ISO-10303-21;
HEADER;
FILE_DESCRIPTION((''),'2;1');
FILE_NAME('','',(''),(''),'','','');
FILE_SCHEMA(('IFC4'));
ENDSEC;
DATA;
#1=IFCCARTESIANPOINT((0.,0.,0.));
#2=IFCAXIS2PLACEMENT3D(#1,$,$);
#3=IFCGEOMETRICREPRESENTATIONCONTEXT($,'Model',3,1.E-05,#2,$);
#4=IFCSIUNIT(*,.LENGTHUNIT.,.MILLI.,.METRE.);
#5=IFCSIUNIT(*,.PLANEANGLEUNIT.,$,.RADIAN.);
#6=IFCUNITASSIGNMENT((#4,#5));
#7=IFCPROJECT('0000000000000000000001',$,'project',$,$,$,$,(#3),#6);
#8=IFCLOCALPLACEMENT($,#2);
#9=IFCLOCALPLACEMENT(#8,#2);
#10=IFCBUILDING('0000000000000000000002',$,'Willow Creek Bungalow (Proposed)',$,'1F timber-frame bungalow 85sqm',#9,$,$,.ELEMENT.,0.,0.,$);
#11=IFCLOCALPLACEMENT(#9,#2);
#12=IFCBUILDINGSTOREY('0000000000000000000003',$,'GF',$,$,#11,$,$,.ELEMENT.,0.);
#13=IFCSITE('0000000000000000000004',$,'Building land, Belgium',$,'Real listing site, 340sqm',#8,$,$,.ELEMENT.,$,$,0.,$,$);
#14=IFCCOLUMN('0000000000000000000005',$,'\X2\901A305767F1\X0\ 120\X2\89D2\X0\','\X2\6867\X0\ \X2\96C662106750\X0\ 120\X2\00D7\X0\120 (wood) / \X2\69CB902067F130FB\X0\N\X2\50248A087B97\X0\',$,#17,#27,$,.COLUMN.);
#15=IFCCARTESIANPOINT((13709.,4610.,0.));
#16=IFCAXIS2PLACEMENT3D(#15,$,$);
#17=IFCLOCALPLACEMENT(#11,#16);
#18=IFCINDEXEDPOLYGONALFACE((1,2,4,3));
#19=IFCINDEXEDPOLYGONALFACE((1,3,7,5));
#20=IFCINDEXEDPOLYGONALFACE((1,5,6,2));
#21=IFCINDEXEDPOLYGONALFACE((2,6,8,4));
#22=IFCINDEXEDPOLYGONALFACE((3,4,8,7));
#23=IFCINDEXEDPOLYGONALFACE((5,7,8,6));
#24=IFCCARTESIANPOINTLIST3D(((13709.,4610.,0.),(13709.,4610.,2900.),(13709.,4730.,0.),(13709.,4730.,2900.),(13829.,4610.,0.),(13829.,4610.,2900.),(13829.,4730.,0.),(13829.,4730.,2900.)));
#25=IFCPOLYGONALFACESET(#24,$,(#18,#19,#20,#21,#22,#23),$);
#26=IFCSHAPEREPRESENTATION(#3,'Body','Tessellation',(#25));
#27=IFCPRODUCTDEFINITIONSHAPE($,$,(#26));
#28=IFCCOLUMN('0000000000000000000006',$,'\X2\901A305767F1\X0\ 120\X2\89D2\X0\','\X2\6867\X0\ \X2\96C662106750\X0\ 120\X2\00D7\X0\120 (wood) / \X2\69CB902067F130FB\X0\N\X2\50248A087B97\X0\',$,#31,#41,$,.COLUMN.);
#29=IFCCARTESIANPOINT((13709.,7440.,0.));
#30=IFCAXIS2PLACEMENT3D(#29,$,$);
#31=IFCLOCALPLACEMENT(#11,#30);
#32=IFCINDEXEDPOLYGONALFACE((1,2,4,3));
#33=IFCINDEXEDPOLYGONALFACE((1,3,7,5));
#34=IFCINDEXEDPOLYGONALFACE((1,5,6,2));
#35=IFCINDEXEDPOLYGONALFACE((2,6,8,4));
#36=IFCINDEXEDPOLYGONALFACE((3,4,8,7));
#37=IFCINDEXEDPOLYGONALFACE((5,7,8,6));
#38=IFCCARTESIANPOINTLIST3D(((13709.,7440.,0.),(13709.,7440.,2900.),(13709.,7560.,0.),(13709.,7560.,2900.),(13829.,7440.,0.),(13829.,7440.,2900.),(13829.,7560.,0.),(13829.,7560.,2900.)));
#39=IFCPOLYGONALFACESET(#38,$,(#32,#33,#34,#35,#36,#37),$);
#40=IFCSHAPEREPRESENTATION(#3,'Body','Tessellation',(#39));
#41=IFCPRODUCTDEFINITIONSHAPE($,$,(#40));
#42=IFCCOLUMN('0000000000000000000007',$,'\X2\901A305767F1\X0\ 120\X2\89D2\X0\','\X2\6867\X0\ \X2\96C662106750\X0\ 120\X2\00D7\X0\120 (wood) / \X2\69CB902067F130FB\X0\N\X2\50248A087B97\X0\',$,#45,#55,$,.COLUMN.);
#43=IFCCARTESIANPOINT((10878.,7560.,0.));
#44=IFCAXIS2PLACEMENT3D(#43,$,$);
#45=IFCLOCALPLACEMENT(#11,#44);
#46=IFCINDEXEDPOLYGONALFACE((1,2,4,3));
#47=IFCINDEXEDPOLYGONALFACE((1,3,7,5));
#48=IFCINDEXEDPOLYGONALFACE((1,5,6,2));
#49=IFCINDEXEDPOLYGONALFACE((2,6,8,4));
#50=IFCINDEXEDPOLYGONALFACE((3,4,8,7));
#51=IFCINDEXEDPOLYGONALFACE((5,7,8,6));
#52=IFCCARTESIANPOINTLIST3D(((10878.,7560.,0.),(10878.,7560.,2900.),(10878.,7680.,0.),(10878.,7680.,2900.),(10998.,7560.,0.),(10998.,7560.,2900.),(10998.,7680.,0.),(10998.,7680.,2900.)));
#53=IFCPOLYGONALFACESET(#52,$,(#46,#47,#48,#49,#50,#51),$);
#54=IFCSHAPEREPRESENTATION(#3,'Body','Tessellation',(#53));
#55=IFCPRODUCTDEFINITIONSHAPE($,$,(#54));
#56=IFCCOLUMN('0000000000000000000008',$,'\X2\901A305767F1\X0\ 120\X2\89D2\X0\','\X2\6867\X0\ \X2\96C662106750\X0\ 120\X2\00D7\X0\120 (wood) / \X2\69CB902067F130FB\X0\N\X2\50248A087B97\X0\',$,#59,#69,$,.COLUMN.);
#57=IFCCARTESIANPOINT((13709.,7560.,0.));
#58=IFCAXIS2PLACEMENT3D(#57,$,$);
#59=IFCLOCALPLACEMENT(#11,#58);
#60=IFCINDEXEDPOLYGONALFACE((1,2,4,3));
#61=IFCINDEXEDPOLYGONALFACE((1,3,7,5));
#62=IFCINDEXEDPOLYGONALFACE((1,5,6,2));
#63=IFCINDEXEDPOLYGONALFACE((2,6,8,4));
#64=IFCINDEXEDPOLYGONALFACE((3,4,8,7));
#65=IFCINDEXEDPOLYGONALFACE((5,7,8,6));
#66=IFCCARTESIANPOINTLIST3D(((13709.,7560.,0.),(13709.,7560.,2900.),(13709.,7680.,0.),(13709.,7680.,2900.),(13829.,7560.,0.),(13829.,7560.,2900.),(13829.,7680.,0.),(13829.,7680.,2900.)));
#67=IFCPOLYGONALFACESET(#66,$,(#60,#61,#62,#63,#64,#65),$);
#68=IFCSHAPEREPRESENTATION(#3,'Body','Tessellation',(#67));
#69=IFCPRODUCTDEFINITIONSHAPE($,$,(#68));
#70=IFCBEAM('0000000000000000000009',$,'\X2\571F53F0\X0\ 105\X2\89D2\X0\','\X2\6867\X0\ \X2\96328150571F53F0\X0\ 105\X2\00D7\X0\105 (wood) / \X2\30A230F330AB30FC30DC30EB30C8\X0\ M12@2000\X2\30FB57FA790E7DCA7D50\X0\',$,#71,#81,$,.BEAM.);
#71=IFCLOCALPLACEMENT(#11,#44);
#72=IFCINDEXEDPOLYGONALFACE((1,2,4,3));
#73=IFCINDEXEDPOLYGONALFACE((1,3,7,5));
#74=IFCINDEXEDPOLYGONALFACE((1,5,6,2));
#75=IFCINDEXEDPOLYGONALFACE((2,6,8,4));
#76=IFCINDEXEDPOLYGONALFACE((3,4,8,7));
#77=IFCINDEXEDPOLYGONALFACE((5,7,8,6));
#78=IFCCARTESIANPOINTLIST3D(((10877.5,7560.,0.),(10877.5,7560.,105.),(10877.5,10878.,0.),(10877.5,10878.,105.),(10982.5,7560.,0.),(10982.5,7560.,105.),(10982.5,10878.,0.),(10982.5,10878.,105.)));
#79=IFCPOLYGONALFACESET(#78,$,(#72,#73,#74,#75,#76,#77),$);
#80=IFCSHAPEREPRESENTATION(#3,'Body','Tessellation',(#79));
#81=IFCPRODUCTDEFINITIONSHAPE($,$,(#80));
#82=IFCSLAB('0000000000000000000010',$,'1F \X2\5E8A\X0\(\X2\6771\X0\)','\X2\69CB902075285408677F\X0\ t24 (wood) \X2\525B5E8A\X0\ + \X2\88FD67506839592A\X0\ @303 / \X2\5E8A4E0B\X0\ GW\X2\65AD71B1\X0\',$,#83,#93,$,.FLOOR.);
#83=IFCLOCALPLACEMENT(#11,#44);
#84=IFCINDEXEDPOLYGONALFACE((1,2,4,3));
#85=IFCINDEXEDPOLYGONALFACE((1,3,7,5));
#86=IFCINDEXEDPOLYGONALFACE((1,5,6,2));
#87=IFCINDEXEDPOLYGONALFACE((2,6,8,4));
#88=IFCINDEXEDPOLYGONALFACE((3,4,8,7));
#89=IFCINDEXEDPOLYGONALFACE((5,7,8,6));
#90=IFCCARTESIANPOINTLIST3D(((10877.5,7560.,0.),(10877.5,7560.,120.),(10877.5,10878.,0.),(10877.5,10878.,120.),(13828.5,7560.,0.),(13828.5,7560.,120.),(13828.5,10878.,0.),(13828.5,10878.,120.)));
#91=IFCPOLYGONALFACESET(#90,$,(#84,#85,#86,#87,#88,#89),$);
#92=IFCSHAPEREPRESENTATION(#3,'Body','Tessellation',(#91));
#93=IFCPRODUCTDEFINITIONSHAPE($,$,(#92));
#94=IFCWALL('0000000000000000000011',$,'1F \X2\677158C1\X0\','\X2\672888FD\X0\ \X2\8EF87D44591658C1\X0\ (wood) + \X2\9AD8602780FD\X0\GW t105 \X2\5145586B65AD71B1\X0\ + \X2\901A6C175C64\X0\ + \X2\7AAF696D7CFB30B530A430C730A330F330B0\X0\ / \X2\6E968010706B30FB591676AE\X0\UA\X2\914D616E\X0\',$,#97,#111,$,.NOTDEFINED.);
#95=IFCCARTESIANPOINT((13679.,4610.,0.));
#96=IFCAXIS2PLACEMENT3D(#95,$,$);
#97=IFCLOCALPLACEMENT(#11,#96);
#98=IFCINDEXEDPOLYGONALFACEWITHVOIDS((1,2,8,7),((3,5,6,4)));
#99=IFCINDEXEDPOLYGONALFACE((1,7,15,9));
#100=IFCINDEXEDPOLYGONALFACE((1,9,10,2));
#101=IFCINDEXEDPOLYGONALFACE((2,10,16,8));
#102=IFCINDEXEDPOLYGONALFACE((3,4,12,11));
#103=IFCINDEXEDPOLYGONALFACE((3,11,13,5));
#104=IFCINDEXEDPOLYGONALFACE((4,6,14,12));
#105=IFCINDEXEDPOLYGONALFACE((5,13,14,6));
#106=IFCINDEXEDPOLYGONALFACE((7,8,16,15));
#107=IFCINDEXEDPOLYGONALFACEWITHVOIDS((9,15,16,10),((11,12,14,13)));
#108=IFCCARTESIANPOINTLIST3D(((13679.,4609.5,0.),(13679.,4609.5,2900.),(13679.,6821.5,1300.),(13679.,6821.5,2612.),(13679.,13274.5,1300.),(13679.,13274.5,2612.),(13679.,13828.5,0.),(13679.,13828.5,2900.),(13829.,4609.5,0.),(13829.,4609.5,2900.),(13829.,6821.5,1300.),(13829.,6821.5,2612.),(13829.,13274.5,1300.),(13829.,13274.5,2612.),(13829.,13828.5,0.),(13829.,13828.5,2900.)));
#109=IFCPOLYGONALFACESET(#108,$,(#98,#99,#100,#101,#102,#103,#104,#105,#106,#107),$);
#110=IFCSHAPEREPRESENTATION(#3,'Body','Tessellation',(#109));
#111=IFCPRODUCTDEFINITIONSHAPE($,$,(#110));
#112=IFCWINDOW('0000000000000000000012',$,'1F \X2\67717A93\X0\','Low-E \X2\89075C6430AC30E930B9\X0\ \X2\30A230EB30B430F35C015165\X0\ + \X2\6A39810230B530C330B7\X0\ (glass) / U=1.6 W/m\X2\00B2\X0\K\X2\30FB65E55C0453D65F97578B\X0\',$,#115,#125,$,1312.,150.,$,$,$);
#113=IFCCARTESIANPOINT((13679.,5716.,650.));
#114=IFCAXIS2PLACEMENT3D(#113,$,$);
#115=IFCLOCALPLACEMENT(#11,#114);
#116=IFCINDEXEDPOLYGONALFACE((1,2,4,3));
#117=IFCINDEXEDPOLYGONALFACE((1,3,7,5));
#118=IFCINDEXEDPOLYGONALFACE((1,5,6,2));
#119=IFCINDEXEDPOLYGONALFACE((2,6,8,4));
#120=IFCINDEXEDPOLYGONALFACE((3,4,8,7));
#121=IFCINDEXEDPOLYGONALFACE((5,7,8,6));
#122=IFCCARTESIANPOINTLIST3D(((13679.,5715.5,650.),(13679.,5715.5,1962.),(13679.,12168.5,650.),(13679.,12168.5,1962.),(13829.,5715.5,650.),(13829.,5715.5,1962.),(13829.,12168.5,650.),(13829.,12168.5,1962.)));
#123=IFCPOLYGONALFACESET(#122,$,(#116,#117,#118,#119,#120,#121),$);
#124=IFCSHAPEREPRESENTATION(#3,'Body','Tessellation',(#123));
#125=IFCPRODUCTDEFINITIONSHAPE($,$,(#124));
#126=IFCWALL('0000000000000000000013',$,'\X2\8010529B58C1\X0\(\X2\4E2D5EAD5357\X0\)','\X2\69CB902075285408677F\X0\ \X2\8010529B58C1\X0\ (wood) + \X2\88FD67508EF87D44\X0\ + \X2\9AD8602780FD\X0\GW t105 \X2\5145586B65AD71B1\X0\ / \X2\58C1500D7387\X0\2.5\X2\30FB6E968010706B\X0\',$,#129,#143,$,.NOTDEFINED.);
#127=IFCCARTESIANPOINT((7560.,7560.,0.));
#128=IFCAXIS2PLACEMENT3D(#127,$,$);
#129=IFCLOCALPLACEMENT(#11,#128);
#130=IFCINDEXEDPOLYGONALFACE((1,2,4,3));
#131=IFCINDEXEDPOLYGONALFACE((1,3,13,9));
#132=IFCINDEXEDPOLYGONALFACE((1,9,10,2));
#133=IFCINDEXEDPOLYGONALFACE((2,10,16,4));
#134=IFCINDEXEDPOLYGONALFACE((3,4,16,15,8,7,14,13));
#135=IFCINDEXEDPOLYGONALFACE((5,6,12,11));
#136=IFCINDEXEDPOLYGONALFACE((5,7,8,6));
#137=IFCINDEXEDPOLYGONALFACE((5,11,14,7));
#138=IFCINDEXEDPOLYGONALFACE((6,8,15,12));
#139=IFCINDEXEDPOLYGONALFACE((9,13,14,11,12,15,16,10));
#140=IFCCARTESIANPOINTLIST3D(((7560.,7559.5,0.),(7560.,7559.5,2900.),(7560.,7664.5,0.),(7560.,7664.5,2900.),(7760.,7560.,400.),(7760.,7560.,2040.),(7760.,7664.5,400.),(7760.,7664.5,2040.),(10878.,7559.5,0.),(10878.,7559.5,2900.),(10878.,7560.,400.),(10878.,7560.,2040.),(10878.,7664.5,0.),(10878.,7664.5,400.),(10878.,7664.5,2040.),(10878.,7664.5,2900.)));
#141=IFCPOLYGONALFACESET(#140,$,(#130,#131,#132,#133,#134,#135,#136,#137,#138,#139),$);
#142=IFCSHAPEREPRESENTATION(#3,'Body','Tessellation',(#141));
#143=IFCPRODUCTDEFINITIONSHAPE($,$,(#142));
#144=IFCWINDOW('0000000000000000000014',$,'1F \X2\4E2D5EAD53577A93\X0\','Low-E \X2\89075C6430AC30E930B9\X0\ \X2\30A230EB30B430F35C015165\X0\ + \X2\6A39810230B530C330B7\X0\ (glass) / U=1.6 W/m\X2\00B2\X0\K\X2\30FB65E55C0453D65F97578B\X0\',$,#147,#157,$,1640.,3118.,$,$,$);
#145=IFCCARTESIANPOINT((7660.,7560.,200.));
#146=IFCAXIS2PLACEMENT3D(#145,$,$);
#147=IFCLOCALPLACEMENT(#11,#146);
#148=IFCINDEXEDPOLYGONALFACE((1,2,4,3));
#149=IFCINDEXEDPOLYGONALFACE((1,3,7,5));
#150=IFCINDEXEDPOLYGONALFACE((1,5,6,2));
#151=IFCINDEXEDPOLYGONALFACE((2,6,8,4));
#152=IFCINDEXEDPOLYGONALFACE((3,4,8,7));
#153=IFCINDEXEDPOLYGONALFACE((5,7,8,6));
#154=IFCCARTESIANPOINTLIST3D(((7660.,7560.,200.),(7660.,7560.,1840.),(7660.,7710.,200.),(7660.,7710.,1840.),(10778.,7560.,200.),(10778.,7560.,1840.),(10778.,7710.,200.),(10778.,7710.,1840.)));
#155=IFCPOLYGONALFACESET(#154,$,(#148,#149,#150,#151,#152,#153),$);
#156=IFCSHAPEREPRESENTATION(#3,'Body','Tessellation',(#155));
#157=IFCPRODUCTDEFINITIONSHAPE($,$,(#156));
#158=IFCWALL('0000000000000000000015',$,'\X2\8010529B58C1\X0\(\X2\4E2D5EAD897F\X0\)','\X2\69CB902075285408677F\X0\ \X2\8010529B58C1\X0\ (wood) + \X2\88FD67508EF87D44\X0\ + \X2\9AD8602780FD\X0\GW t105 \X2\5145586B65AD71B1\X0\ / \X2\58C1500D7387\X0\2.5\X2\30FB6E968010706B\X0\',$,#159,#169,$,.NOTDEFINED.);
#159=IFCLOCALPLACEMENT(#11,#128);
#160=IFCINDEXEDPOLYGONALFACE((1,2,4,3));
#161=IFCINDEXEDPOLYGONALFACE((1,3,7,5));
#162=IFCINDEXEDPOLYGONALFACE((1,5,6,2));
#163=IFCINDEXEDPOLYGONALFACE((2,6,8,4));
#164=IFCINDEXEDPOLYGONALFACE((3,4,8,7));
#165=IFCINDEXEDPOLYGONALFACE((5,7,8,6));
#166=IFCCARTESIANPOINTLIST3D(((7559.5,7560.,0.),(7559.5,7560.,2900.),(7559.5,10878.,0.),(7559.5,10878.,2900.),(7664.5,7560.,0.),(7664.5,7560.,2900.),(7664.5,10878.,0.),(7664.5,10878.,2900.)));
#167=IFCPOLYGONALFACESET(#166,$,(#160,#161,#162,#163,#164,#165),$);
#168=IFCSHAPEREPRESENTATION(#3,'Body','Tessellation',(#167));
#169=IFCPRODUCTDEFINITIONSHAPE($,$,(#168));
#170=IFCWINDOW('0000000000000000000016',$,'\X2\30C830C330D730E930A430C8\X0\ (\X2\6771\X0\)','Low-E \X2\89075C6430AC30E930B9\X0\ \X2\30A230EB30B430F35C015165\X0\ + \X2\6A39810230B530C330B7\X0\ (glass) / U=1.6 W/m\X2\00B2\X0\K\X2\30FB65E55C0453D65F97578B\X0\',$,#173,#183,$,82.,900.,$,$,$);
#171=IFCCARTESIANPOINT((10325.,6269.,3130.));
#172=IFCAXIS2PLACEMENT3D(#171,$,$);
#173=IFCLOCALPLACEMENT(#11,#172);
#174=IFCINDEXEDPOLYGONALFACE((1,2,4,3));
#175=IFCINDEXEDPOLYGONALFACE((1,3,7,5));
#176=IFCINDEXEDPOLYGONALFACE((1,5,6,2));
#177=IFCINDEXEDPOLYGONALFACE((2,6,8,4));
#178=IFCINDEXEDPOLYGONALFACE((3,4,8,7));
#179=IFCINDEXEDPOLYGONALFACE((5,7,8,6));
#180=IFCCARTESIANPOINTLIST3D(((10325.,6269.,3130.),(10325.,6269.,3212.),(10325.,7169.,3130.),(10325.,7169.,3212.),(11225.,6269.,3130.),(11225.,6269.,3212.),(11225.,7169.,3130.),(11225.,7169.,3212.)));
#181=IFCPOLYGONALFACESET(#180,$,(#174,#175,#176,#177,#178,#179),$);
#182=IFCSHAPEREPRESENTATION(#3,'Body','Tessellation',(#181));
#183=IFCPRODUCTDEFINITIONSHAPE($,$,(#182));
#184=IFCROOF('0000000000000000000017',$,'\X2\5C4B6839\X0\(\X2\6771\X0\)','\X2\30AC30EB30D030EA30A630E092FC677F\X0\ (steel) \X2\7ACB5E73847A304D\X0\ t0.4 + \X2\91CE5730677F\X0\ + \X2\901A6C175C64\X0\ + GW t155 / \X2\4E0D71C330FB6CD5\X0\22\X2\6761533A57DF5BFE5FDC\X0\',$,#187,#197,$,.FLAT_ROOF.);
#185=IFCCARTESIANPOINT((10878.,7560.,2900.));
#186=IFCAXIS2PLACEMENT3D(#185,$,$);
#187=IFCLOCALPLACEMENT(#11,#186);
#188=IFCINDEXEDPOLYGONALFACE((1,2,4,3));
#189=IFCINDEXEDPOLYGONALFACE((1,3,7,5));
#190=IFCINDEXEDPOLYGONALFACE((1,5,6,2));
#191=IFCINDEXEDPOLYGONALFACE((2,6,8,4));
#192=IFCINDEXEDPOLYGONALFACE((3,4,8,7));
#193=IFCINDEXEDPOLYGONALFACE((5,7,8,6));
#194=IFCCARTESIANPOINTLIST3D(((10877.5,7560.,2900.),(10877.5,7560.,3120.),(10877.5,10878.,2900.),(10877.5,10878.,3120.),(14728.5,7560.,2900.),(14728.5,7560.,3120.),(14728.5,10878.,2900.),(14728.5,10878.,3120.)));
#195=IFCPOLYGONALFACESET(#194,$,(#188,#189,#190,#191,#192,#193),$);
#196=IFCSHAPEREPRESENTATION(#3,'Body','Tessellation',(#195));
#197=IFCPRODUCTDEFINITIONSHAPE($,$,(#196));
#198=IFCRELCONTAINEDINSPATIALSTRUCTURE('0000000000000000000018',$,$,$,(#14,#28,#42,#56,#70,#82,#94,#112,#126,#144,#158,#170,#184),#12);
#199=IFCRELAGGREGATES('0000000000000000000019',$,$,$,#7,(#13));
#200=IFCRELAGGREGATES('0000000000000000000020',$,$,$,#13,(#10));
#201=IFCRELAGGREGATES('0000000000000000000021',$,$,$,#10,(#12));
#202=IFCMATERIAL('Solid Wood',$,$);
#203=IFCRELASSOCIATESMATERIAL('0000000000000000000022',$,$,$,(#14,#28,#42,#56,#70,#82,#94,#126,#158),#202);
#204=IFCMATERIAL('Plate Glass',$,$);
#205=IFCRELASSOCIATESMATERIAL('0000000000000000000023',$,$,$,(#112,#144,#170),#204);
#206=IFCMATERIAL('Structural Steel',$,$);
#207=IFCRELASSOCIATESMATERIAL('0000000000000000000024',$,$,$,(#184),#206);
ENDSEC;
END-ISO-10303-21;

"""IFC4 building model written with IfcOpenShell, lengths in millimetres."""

from ifc_helpers import new_model, si_unit, frame, frame_2d, origin, place, context, project, spatial, rectangle, extrude, material, element, fill, save


model = new_model("IFC4")

# Units and contexts
model_context = context("Model", 3, precision=1e-05, world=origin())
ifc_project = project(units=[si_unit("LENGTHUNIT", "METRE", prefix="MILLI"), si_unit("PLANEANGLEUNIT", "RADIAN")], contexts=[model_context])

# Site, building, storey
site_placement = place(None, origin())
site = spatial("IfcSite", under=ifc_project, at=site_placement, Name="Building land, Belgium", ObjectType="Real listing site, 340sqm", CompositionType="ELEMENT", RefElevation=0.0)
building_placement = place(site_placement, origin())
building = spatial("IfcBuilding", under=site, at=building_placement, Name="Willow Creek Bungalow (Proposed)", ObjectType="1F timber-frame bungalow 85sqm", CompositionType="ELEMENT", ElevationOfRefHeight=0.0, ElevationOfTerrain=0.0)
storey_placement = place(building_placement, origin())
storey = spatial("IfcBuildingStorey", under=building, at=storey_placement, Name="GF", CompositionType="ELEMENT", Elevation=0.0)

# Columns
ifc_material_1 = material(Name="Solid Wood")
column_1_placement = place(storey_placement, frame((13709.0, 4610.0, 0.0)))
element("IfcColumn", 1, at=column_1_placement, inside=storey, material=ifc_material_1, Name="通し柱 120角", Description="桧 集成材 120×120 (wood) / 構造柱・N値計算", PredefinedType="COLUMN", context=model_context, shape_type="SweptSolid", body=[
    extrude(rectangle(XDim=120.0, YDim=120.0, at=frame_2d((60.0, 60.0))), frame((13709.0, 4610.0, 0.0)), (0.0, 0.0, 1.0), 2900.0),
])
column_2_placement = place(storey_placement, frame((13709.0, 7440.0, 0.0)))
element("IfcColumn", 2, at=column_2_placement, inside=storey, material=ifc_material_1, Name="通し柱 120角", Description="桧 集成材 120×120 (wood) / 構造柱・N値計算", PredefinedType="COLUMN", context=model_context, shape_type="SweptSolid", body=[
    extrude(rectangle(XDim=120.0, YDim=120.0, at=frame_2d((60.0, 60.0))), frame((13709.0, 7440.0, 0.0)), (0.0, 0.0, 1.0), 2900.0),
])
column_3_placement = place(storey_placement, frame((10878.0, 7560.0, 0.0)))
element("IfcColumn", 3, at=column_3_placement, inside=storey, material=ifc_material_1, Name="通し柱 120角", Description="桧 集成材 120×120 (wood) / 構造柱・N値計算", PredefinedType="COLUMN", context=model_context, shape_type="SweptSolid", body=[
    extrude(rectangle(XDim=120.0, YDim=120.0, at=frame_2d((60.0, 60.0))), frame((10878.0, 7560.0, 0.0)), (0.0, 0.0, 1.0), 2900.0),
])
column_4_placement = place(storey_placement, frame((13709.0, 7560.0, 0.0)))
element("IfcColumn", 4, at=column_4_placement, inside=storey, material=ifc_material_1, Name="通し柱 120角", Description="桧 集成材 120×120 (wood) / 構造柱・N値計算", PredefinedType="COLUMN", context=model_context, shape_type="SweptSolid", body=[
    extrude(rectangle(XDim=120.0, YDim=120.0, at=frame_2d((60.0, 60.0))), frame((13709.0, 7560.0, 0.0)), (0.0, 0.0, 1.0), 2900.0),
])

# Beam
beam_1_placement = place(storey_placement, frame((10878.0, 7560.0, 0.0)))
element("IfcBeam", 5, at=beam_1_placement, inside=storey, material=ifc_material_1, Name="土台 105角", Description="桧 防腐土台 105×105 (wood) / アンカーボルト M12@2000・基礎緊結", PredefinedType="BEAM", context=model_context, shape_type="SweptSolid", body=[
    extrude(rectangle(XDim=105.0, YDim=3318.0, at=frame_2d((52.0, 1659.0))), frame((10878.0, 7560.0, 0.0)), (0.0, 0.0, 1.0), 105.0),
])

# Slab
slab_placement = place(storey_placement, frame((10878.0, 7560.0, 0.0)))
element("IfcSlab", 6, at=slab_placement, inside=storey, material=ifc_material_1, Name="1F 床(東)", Description="構造用合板 t24 (wood) 剛床 + 製材根太 @303 / 床下 GW断熱", PredefinedType="FLOOR", context=model_context, shape_type="SweptSolid", body=[
    extrude(rectangle(XDim=2951.0, YDim=3318.0, at=frame_2d((1475.0, 1659.0))), frame((10878.0, 7560.0, 0.0)), (0.0, 0.0, 1.0), 120.0),
])

# Walls, openings, windows
wall_1_placement = place(storey_placement, frame((13679.0, 4610.0, 0.0)))
wall_1 = element("IfcWall", 7, at=wall_1_placement, inside=storey, material=ifc_material_1, Name="1F 東壁", Description="木製 軸組外壁 (wood) + 高性能GW t105 充填断熱 + 通気層 + 窯業系サイディング / 準耐火・外皮UA配慮", PredefinedType="NOTDEFINED", context=model_context, shape_type="SweptSolid", body=[
    extrude(rectangle(XDim=150.0, YDim=9219.0, at=frame_2d((75.0, 4609.0))), frame((13679.0, 4610.0, 0.0)), (0.0, 0.0, 1.0), 2900.0),
])
opening_1_placement = place(storey_placement, frame((13679.0, 5716.0, 650.0)))
opening_1 = element("IfcOpeningElement", 8, at=opening_1_placement, cuts=wall_1, PredefinedType="NOTDEFINED", context=model_context, shape_type="SweptSolid", body=[
    extrude(rectangle(XDim=150.0, YDim=6453.0, at=frame_2d((75.0, 3226.0))), frame((13679.0, 5716.0, 650.0)), (0.0, 0.0, 1.0), 1312.0),
])
ifc_material_2 = material(Name="Plate Glass")
window_1_placement = place(storey_placement, frame((13679.0, 5716.0, 650.0)))
window_1 = element("IfcWindow", 9, at=window_1_placement, inside=storey, material=ifc_material_2, Name="1F 東窓", Description="Low-E 複層ガラス アルゴン封入 + 樹脂サッシ (glass) / U=1.6 W/m²K・日射取得型", OverallHeight=1312.0, OverallWidth=150.0, context=model_context, shape_type="SweptSolid", body=[
    extrude(rectangle(XDim=150.0, YDim=6453.0, at=frame_2d((75.0, 3226.0))), frame((13679.0, 5716.0, 650.0)), (0.0, 0.0, 1.0), 1312.0),
])
fill(opening_1, window_1)
wall_2_placement = place(storey_placement, frame((7560.0, 7560.0, 0.0)))
wall_2 = element("IfcWall", 10, at=wall_2_placement, inside=storey, material=ifc_material_1, Name="耐力壁(中庭南)", Description="構造用合板 耐力壁 (wood) + 製材軸組 + 高性能GW t105 充填断熱 / 壁倍率2.5・準耐火", PredefinedType="NOTDEFINED", context=model_context, shape_type="SweptSolid", body=[
    extrude(rectangle(XDim=3318.0, YDim=105.0, at=frame_2d((1659.0, 52.0))), frame((7560.0, 7560.0, 0.0)), (0.0, 0.0, 1.0), 2900.0),
])
opening_2_placement = place(storey_placement, frame((7660.0, 7560.0, 200.0)))
opening_2 = element("IfcOpeningElement", 11, at=opening_2_placement, cuts=wall_2, PredefinedType="NOTDEFINED", context=model_context, shape_type="SweptSolid", body=[
    extrude(rectangle(XDim=3118.0, YDim=150.0, at=frame_2d((1559.0, 75.0))), frame((7660.0, 7560.0, 200.0)), (0.0, 0.0, 1.0), 1640.0),
])
window_2_placement = place(storey_placement, frame((7660.0, 7560.0, 200.0)))
window_2 = element("IfcWindow", 12, at=window_2_placement, inside=storey, material=ifc_material_2, Name="1F 中庭南窓", Description="Low-E 複層ガラス アルゴン封入 + 樹脂サッシ (glass) / U=1.6 W/m²K・日射取得型", OverallHeight=1640.0, OverallWidth=3118.0, context=model_context, shape_type="SweptSolid", body=[
    extrude(rectangle(XDim=3118.0, YDim=150.0, at=frame_2d((1559.0, 75.0))), frame((7660.0, 7560.0, 200.0)), (0.0, 0.0, 1.0), 1640.0),
])
fill(opening_2, window_2)

# Wall
wall_3_placement = place(storey_placement, frame((7560.0, 7560.0, 0.0)))
element("IfcWall", 13, at=wall_3_placement, inside=storey, material=ifc_material_1, Name="耐力壁(中庭西)", Description="構造用合板 耐力壁 (wood) + 製材軸組 + 高性能GW t105 充填断熱 / 壁倍率2.5・準耐火", PredefinedType="NOTDEFINED", context=model_context, shape_type="SweptSolid", body=[
    extrude(rectangle(XDim=105.0, YDim=3318.0, at=frame_2d((52.0, 1659.0))), frame((7560.0, 7560.0, 0.0)), (0.0, 0.0, 1.0), 2900.0),
])

# Window
window_3_placement = place(storey_placement, frame((10325.0, 6269.0, 3130.0)))
element("IfcWindow", 14, at=window_3_placement, inside=storey, material=ifc_material_2, Name="トップライト (東)", Description="Low-E 複層ガラス アルゴン封入 + 樹脂サッシ (glass) / U=1.6 W/m²K・日射取得型", OverallHeight=82.0, OverallWidth=900.0, context=model_context, shape_type="SweptSolid", body=[
    extrude(rectangle(XDim=900.0, YDim=900.0, at=frame_2d((450.0, 450.0))), frame((10325.0, 6269.0, 3130.0)), (0.0, 0.0, 1.0), 82.0),
])

# Roof
ifc_material_3 = material(Name="Structural Steel")
roof_placement = place(storey_placement, frame((10878.0, 7560.0, 2900.0)))
element("IfcRoof", 15, at=roof_placement, inside=storey, material=ifc_material_3, Name="屋根(東)", Description="ガルバリウム鋼板 (steel) 立平葺き t0.4 + 野地板 + 通気層 + GW t155 / 不燃・法22条区域対応", PredefinedType="FLAT_ROOF", context=model_context, shape_type="SweptSolid", body=[
    extrude(rectangle(XDim=3851.0, YDim=3318.0, at=frame_2d((1925.0, 1659.0))), frame((10878.0, 7560.0, 2900.0)), (0.0, 0.0, 1.0), 220.0),
])

save(model, "model.ifc")
